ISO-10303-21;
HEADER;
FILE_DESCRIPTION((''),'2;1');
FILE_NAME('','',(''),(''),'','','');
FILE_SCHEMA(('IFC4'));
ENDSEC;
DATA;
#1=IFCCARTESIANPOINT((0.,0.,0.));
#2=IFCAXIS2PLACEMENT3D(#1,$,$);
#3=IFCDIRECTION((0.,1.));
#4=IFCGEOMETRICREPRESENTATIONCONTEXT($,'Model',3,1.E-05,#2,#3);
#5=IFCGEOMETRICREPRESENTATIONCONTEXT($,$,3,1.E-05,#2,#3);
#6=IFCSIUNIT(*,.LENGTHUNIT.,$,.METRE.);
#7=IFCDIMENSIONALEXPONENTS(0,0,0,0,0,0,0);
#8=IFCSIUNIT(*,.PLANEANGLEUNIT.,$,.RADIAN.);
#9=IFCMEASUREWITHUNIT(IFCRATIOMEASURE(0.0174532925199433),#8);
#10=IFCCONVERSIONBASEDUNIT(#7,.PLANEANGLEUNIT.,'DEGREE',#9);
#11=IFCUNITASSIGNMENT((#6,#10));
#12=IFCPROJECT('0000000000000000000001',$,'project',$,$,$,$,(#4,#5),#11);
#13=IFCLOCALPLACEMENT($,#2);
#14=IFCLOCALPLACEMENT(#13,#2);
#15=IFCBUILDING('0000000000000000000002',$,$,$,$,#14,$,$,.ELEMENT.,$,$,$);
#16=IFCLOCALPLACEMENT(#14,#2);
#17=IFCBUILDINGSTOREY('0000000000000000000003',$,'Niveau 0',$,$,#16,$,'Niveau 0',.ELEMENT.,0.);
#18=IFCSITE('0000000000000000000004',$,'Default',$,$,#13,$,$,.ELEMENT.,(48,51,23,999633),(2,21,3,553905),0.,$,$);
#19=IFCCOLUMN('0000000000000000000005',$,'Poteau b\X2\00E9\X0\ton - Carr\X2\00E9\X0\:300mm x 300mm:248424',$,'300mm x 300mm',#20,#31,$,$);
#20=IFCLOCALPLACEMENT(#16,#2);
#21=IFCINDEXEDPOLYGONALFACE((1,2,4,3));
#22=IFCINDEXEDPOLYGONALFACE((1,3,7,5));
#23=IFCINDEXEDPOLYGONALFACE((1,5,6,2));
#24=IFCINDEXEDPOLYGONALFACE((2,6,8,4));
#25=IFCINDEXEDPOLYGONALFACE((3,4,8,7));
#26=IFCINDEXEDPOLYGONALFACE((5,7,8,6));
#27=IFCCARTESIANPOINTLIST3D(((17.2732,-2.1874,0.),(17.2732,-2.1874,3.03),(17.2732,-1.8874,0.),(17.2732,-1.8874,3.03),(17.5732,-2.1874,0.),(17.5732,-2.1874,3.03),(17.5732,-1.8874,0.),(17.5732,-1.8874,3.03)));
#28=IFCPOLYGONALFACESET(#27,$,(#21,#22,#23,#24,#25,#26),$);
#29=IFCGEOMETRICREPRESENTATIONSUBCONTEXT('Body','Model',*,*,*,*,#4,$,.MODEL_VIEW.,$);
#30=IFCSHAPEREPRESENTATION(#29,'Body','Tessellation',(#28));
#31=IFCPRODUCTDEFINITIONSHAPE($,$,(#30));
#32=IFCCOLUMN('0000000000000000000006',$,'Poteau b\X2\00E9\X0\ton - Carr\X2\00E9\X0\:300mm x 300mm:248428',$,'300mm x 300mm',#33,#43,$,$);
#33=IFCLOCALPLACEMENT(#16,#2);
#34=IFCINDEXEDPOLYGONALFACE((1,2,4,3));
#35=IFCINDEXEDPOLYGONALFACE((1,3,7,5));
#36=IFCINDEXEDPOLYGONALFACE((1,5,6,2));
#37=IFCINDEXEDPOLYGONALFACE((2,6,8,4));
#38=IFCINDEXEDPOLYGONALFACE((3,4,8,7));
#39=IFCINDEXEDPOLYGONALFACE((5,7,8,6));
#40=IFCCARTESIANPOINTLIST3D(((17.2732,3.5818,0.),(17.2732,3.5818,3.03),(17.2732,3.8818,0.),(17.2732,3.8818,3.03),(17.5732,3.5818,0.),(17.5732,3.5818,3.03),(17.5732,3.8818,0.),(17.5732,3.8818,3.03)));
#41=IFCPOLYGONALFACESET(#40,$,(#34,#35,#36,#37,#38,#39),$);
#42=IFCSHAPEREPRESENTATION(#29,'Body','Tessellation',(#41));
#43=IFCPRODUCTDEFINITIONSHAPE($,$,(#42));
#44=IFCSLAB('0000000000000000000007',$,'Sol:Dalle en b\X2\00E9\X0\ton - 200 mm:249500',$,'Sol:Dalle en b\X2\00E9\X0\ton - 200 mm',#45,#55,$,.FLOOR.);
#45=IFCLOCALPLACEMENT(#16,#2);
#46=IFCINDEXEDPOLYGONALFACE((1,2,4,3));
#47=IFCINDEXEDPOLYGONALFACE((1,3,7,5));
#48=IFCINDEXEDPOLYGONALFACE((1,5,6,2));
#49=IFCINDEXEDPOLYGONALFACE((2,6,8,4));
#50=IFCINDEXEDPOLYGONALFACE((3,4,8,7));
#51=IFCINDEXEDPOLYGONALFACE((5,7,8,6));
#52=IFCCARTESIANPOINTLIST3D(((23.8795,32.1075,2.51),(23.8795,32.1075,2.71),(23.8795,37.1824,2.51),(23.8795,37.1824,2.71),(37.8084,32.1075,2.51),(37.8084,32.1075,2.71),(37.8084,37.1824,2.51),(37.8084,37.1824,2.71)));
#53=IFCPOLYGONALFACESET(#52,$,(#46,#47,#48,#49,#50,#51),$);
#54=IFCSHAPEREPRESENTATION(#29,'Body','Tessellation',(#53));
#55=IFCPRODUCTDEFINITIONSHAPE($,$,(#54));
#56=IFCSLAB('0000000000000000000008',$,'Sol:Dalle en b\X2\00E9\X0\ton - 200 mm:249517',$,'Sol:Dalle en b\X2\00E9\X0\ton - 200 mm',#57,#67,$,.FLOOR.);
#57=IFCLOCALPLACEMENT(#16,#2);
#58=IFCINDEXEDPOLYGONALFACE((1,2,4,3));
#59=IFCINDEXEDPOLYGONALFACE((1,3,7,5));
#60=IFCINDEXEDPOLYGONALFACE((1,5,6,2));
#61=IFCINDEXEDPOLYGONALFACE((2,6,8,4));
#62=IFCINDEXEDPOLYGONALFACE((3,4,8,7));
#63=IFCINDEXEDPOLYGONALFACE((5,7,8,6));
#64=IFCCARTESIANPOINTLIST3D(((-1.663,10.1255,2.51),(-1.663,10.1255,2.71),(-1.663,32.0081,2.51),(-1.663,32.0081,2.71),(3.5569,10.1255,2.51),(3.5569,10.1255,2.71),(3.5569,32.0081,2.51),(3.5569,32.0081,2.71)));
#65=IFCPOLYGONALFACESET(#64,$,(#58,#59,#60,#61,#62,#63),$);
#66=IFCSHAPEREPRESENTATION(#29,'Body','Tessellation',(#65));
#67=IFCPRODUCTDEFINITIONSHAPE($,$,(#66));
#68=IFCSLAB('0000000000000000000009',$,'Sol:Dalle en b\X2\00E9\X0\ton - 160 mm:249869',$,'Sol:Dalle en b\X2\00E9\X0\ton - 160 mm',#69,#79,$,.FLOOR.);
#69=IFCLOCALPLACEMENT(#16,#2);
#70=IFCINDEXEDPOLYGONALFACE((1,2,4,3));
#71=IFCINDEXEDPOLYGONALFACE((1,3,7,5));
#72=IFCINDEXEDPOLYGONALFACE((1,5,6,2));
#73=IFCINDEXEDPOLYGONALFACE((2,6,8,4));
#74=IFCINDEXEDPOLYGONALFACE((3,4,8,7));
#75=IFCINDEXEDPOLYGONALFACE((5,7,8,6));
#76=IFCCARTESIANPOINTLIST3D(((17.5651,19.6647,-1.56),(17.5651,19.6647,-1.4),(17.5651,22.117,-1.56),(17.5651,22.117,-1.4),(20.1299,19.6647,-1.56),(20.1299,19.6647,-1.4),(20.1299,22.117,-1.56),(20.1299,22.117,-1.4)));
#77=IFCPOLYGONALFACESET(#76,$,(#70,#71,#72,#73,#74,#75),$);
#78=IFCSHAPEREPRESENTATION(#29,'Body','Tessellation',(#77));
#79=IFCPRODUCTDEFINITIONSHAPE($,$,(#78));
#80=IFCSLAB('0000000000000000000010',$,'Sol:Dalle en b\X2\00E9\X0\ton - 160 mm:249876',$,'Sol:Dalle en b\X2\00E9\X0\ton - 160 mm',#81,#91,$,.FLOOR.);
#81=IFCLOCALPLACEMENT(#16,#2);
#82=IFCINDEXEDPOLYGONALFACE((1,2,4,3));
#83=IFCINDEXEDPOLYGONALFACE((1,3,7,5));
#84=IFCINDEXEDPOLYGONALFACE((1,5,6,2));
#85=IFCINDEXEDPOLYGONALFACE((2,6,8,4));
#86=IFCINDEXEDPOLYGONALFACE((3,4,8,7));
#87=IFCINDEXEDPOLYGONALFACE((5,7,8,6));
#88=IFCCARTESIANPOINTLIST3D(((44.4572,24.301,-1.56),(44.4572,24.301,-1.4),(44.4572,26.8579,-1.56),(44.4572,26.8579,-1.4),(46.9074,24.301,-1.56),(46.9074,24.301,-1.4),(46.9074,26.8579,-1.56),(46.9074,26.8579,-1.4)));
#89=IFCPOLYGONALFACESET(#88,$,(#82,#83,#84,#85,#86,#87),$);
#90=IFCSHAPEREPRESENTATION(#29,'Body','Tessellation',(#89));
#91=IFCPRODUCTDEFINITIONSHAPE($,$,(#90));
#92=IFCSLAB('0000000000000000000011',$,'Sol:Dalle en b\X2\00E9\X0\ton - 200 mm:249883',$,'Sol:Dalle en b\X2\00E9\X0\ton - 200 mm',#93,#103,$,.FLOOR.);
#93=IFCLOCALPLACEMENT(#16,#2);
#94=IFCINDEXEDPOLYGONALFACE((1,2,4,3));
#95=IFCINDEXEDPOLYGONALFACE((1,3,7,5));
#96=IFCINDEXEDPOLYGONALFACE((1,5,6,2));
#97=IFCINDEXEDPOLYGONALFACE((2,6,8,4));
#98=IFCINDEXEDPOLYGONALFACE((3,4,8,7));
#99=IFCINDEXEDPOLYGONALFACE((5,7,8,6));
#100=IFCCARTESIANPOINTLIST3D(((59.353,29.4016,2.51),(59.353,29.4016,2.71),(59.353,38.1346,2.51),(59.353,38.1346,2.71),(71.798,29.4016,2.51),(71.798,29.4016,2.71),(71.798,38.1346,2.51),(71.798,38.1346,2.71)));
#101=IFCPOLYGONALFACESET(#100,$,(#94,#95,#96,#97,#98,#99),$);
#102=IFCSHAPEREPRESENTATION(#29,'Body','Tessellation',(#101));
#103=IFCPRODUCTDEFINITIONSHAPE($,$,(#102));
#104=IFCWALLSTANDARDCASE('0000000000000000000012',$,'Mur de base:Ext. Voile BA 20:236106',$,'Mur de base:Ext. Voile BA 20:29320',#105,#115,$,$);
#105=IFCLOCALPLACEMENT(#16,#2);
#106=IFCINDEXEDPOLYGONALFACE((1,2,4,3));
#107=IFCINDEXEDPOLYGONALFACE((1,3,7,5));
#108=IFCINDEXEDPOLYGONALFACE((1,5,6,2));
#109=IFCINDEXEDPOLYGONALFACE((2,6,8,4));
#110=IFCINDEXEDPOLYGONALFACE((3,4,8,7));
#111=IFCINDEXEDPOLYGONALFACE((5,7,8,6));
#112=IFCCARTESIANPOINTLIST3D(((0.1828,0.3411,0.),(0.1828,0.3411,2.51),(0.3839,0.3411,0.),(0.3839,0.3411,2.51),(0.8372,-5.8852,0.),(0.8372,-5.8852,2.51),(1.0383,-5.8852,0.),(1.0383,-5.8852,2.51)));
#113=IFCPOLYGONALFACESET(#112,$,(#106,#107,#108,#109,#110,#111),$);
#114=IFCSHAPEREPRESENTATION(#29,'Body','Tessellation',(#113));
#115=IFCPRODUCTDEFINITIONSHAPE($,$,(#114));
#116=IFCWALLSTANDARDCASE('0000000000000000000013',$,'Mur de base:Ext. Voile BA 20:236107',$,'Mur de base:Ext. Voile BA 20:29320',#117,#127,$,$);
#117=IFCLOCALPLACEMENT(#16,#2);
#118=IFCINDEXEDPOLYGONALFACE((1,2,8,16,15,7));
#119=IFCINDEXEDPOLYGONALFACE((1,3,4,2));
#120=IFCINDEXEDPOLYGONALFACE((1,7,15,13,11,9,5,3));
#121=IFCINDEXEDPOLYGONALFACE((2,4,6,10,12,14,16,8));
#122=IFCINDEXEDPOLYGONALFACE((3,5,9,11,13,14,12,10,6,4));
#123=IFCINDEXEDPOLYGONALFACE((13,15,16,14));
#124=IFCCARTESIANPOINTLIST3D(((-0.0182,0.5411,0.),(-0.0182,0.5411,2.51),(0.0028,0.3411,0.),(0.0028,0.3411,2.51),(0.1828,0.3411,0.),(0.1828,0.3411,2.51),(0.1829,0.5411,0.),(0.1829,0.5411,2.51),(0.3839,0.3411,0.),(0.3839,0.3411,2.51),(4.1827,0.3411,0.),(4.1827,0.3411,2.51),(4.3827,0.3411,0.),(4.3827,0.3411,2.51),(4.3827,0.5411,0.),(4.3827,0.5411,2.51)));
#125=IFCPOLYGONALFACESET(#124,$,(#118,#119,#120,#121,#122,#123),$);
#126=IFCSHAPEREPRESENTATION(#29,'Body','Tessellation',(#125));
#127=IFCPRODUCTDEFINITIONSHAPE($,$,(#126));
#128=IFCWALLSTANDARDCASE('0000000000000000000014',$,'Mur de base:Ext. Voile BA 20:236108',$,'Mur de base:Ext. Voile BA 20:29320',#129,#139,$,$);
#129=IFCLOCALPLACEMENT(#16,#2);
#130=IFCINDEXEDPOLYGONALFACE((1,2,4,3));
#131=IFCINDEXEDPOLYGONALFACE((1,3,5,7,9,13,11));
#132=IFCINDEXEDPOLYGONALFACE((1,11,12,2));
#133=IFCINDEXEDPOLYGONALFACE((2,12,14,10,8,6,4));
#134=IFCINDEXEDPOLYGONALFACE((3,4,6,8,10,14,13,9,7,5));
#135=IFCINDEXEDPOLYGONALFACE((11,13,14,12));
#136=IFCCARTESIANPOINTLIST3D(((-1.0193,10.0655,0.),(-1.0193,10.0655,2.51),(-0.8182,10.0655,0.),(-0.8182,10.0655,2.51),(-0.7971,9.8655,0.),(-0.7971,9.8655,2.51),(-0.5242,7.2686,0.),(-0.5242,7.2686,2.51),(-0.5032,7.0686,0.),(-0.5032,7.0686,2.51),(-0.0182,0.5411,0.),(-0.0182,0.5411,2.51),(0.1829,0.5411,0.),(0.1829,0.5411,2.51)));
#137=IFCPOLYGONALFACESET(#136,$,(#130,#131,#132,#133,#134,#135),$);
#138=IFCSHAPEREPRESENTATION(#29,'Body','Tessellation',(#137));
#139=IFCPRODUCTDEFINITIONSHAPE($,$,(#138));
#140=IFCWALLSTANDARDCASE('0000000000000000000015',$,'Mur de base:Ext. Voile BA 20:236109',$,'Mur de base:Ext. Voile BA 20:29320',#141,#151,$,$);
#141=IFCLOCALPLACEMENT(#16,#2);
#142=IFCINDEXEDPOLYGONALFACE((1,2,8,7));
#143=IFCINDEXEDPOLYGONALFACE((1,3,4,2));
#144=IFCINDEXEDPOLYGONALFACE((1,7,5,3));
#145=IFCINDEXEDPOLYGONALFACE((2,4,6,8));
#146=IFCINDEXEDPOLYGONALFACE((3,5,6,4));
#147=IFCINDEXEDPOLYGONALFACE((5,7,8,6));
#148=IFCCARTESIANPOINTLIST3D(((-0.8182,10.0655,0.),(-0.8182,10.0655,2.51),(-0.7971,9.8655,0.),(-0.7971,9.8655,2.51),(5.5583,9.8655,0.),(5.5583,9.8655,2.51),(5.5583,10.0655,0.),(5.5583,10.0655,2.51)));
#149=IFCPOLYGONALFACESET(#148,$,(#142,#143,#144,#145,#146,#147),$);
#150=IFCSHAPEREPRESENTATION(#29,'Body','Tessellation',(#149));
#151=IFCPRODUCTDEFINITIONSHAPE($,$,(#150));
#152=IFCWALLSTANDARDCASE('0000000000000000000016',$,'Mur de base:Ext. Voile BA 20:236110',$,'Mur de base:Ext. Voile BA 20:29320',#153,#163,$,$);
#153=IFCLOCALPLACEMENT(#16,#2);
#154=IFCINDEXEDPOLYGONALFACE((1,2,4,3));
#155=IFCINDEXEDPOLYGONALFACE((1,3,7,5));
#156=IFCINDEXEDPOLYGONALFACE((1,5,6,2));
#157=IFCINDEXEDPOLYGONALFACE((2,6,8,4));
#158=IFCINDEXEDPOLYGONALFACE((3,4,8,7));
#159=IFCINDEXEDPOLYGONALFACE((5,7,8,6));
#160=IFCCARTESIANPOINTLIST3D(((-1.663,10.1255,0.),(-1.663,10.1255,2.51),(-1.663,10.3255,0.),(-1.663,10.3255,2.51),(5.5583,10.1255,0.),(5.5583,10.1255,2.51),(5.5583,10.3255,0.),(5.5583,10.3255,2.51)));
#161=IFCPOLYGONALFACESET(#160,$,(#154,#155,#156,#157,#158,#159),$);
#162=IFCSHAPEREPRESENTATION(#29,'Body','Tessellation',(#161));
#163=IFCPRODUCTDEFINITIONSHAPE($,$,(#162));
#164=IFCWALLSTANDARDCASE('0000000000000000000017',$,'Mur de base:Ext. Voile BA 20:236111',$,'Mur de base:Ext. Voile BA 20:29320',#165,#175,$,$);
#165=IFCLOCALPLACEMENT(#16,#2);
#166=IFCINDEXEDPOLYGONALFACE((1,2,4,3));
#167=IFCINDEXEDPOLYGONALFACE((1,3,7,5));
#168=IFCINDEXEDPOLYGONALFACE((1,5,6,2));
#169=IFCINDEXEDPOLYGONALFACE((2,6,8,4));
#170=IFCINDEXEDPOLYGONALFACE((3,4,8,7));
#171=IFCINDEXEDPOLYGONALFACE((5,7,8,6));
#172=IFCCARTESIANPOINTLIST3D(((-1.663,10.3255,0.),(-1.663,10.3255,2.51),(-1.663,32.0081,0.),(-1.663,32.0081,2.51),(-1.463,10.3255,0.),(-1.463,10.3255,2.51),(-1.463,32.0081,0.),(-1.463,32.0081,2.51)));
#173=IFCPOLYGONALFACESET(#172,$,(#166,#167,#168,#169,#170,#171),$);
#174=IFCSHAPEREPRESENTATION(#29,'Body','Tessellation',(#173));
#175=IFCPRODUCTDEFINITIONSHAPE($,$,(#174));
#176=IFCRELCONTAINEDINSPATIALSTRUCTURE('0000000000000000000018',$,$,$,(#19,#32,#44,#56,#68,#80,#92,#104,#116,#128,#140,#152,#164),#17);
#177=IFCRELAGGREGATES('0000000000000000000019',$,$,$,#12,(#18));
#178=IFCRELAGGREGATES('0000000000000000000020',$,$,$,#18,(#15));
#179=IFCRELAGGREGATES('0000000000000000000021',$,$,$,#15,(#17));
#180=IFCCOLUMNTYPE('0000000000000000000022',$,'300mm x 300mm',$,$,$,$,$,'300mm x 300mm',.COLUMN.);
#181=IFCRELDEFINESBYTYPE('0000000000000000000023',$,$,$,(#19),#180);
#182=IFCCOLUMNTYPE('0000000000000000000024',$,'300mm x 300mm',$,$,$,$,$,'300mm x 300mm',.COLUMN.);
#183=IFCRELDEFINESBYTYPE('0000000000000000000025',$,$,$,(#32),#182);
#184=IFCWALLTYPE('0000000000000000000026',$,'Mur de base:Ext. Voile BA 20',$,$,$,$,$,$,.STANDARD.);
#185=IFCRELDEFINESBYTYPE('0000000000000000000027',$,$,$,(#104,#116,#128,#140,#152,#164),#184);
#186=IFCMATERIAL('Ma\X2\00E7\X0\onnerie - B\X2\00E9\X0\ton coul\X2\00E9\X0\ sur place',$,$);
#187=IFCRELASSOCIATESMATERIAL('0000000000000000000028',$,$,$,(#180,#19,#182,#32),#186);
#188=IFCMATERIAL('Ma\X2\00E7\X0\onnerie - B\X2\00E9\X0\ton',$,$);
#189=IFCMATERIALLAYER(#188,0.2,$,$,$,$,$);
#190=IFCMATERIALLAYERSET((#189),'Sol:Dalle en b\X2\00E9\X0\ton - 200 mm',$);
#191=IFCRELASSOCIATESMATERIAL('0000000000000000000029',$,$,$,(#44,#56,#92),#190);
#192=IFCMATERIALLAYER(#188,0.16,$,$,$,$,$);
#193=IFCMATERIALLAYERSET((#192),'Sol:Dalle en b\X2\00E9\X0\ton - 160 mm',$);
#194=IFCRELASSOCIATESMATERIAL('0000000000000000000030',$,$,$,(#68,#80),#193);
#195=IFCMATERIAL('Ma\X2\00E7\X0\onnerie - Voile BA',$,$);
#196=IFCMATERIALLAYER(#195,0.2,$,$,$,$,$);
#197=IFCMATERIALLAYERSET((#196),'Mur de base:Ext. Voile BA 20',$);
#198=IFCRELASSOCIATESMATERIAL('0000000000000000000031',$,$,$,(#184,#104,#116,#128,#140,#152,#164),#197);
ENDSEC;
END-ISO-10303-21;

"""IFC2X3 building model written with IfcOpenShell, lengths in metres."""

from ifc_helpers import new_model, entity, si_unit, converted_unit, direction, frame, frame_2d, origin, origin_2d_with_axis, place, context, subcontext, project, spatial, polyline, rectangle, outline, extrude, source, transform, mapped, material, layer, layer_set, layer_usage, type_object, type_shapes, element, save


model = new_model("IFC2X3")

# Units and contexts
model_context = context("Model", 3, precision=1e-05, world=origin(), true_north=direction((0.0, 1.0)))
context_of_model = context(None, 3, precision=1e-05, world=origin(), true_north=direction((0.0, 1.0)))
body_context = subcontext(model_context, "Body", "Model", "MODEL_VIEW")
ifc_project = project(units=[si_unit("LENGTHUNIT", "METRE"), converted_unit("PLANEANGLEUNIT", "DEGREE", entity("IfcRatioMeasure", 0.0174532925199433), si_unit("PLANEANGLEUNIT", "RADIAN"), dimensions=[0, 0, 0, 0, 0, 0, 0])], contexts=[model_context, context_of_model])

# Site, building, storey
site_placement = place(None, origin())
site = spatial("IfcSite", under=ifc_project, at=site_placement, Name="Default", CompositionType="ELEMENT", RefLatitude=(48, 51, 23, 999633), RefLongitude=(2, 21, 3, 553905), RefElevation=0.0)
building_placement = place(site_placement, origin())
building = spatial("IfcBuilding", under=site, at=building_placement, CompositionType="ELEMENT")
storey_placement = place(building_placement, origin())
storey = spatial("IfcBuildingStorey", under=building, at=storey_placement, Name="Niveau 0", LongName="Niveau 0", CompositionType="ELEMENT", Elevation=0.0)

# Columns
ifc_material_1 = material(Name="Maçonnerie - Béton coulé sur place")
column_type_1 = type_object("IfcColumnType", Name="300mm x 300mm", ElementType="300mm x 300mm", PredefinedType="COLUMN", material=ifc_material_1)
shared_shape_1 = source(origin(), body_context, "Body", "SweptSolid", [
    extrude(rectangle(XDim=0.3, YDim=0.3, at=frame_2d((0.0, 0.0), x_axis=(1.0, 0.0))), frame((17.4232, -2.0374, 0.0), z_axis=(0.0, 0.0, 1.0), x_axis=(-1.0, 0.0, 0.0)), (0.0, 0.0, 1.0), 3.03),
])
type_shapes(column_type_1, [shared_shape_1])
column_1_placement = place(storey_placement, origin())
element("IfcColumn", 1, at=column_1_placement, inside=storey, type_object=column_type_1, material=ifc_material_1, Name="Poteau béton - Carré:300mm x 300mm:248424", ObjectType="300mm x 300mm", context=body_context, shape_type="MappedRepresentation", body=[
    mapped(shared_shape_1, transform((0.0, 0.0, 0.0), scale=1.0)),
])
column_type_2 = type_object("IfcColumnType", Name="300mm x 300mm", ElementType="300mm x 300mm", PredefinedType="COLUMN", material=ifc_material_1)
shared_shape_2 = source(origin(), body_context, "Body", "SweptSolid", [
    extrude(rectangle(XDim=0.3, YDim=0.3, at=frame_2d((0.0, 0.0), x_axis=(1.0, 0.0))), frame((17.4232, 3.7318, 0.0), z_axis=(0.0, 0.0, 1.0), x_axis=(-1.0, 0.0, 0.0)), (0.0, 0.0, 1.0), 3.03),
])
type_shapes(column_type_2, [shared_shape_2])
column_2_placement = place(storey_placement, origin())
element("IfcColumn", 2, at=column_2_placement, inside=storey, type_object=column_type_2, material=ifc_material_1, Name="Poteau béton - Carré:300mm x 300mm:248428", ObjectType="300mm x 300mm", context=body_context, shape_type="MappedRepresentation", body=[
    mapped(shared_shape_2, transform((0.0, 0.0, 0.0), scale=1.0)),
])

# Slabs
ifc_material_2 = material(Name="Maçonnerie - Béton")
ifc_layer_1 = layer(ifc_material_2, 0.2)
ifc_layer_set_1 = layer_set([ifc_layer_1], Name="Sol:Dalle en béton - 200 mm")
ifc_layer_usage_1 = layer_usage(ifc_layer_set_1, "AXIS3", "POSITIVE", 0.0)
slab_1_placement = place(storey_placement, origin())
element("IfcSlab", 3, at=slab_1_placement, inside=storey, material=ifc_layer_usage_1, Name="Sol:Dalle en béton - 200 mm:249500", ObjectType="Sol:Dalle en béton - 200 mm", PredefinedType="FLOOR", context=body_context, shape_type="SweptSolid", body=[
    extrude(rectangle(XDim=5.0749, YDim=13.9289, at=frame_2d((0.0, 0.0), x_axis=(1.0, 0.0))), frame((30.8439, 34.645, 2.71), z_axis=(0.0, 0.0, -1.0), x_axis=(0.0, 1.0, 0.0)), (0.0, 0.0, 1.0), 0.2),
])
ifc_layer_usage_2 = layer_usage(ifc_layer_set_1, "AXIS3", "POSITIVE", 0.0)
slab_2_placement = place(storey_placement, origin())
element("IfcSlab", 4, at=slab_2_placement, inside=storey, material=ifc_layer_usage_2, Name="Sol:Dalle en béton - 200 mm:249517", ObjectType="Sol:Dalle en béton - 200 mm", PredefinedType="FLOOR", context=body_context, shape_type="SweptSolid", body=[
    extrude(rectangle(XDim=21.8826, YDim=5.2199, at=frame_2d((0.0, 0.0), x_axis=(1.0, 0.0))), frame((0.947, 21.0668, 2.71), z_axis=(0.0, 0.0, -1.0), x_axis=(0.0, 1.0, 0.0)), (0.0, 0.0, 1.0), 0.2),
])
ifc_layer_2 = layer(ifc_material_2, 0.16)
ifc_layer_set_2 = layer_set([ifc_layer_2], Name="Sol:Dalle en béton - 160 mm")
ifc_layer_usage_3 = layer_usage(ifc_layer_set_2, "AXIS3", "POSITIVE", 0.0)
slab_3_placement = place(storey_placement, origin())
element("IfcSlab", 5, at=slab_3_placement, inside=storey, material=ifc_layer_usage_3, Name="Sol:Dalle en béton - 160 mm:249869", ObjectType="Sol:Dalle en béton - 160 mm", PredefinedType="FLOOR", context=body_context, shape_type="SweptSolid", body=[
    extrude(rectangle(XDim=2.4523, YDim=2.5648, at=origin_2d_with_axis()), frame((18.8475, 20.8908, -1.4), z_axis=(0.0, 0.0, -1.0), x_axis=(0.0, 1.0, 0.0)), (0.0, 0.0, 1.0), 0.16),
])
ifc_layer_usage_4 = layer_usage(ifc_layer_set_2, "AXIS3", "POSITIVE", 0.0)
slab_4_placement = place(storey_placement, origin())
element("IfcSlab", 6, at=slab_4_placement, inside=storey, material=ifc_layer_usage_4, Name="Sol:Dalle en béton - 160 mm:249876", ObjectType="Sol:Dalle en béton - 160 mm", PredefinedType="FLOOR", context=body_context, shape_type="SweptSolid", body=[
    extrude(rectangle(XDim=2.5569, YDim=2.4501, at=frame_2d((0.0, 0.0), x_axis=(1.0, 0.0))), frame((45.6823, 25.5794, -1.4), z_axis=(0.0, 0.0, -1.0), x_axis=(0.0, 1.0, 0.0)), (0.0, 0.0, 1.0), 0.16),
])
ifc_layer_usage_5 = layer_usage(ifc_layer_set_1, "AXIS3", "POSITIVE", 0.0)
slab_5_placement = place(storey_placement, origin())
element("IfcSlab", 7, at=slab_5_placement, inside=storey, material=ifc_layer_usage_5, Name="Sol:Dalle en béton - 200 mm:249883", ObjectType="Sol:Dalle en béton - 200 mm", PredefinedType="FLOOR", context=body_context, shape_type="SweptSolid", body=[
    extrude(rectangle(XDim=8.733, YDim=12.445, at=origin_2d_with_axis()), frame((65.5755, 33.7681, 2.71), z_axis=(0.0, 0.0, -1.0), x_axis=(0.0, 1.0, 0.0)), (0.0, 0.0, 1.0), 0.2),
])

# Walls
ifc_material_3 = material(Name="Maçonnerie - Voile BA")
ifc_layer_3 = layer(ifc_material_3, 0.2)
ifc_layer_set_3 = layer_set([ifc_layer_3], Name="Mur de base:Ext. Voile BA 20")
ifc_layer_usage_6 = layer_usage(ifc_layer_set_3, "AXIS2", "NEGATIVE", 0.1)
wall_type = type_object("IfcWallType", Name="Mur de base:Ext. Voile BA 20", PredefinedType="STANDARD", material=ifc_layer_set_3)
wall_1_placement = place(storey_placement, frame((0.9389, -5.8956, 0.0), z_axis=(0.0, 0.0, 1.0), x_axis=(-0.104528, 0.994522, 0.0)))
element("IfcWallStandardCase", 8, at=wall_1_placement, inside=storey, type_object=wall_type, material=ifc_layer_usage_6, Name="Mur de base:Ext. Voile BA 20:236106", ObjectType="Mur de base:Ext. Voile BA 20:29320", context=body_context, shape_type="SweptSolid", body=[
    extrude(outline(polyline([(6.2606, -0.1), (6.2816, 0.1), (0.021, 0.1), (0.0, -0.1), (6.2606, -0.1)])), origin(), (0.0, 0.0, 1.0), 2.51),
])
ifc_layer_usage_7 = layer_usage(ifc_layer_set_3, "AXIS2", "NEGATIVE", 0.1)
wall_2_placement = place(storey_placement, frame((4.3827, 0.4411, 0.0), z_axis=(0.0, 0.0, 1.0), x_axis=(-1.0, 0.0, 0.0)))
element("IfcWallStandardCase", 9, at=wall_2_placement, inside=storey, type_object=wall_type, material=ifc_layer_usage_7, Name="Mur de base:Ext. Voile BA 20:236107", ObjectType="Mur de base:Ext. Voile BA 20:29320", context=body_context, shape_type="SweptSolid", body=[
    extrude(outline(polyline([(4.4009, -0.1), (4.3799, 0.1), (4.1999, 0.1), (3.9988, 0.1), (0.2, 0.1), (0.0, 0.1), (0.0, -0.1), (4.1998, -0.1), (4.4009, -0.1)])), origin(), (0.0, 0.0, 1.0), 2.51),
])
ifc_layer_usage_8 = layer_usage(ifc_layer_set_3, "AXIS2", "NEGATIVE", 0.1)
wall_3_placement = place(storey_placement, frame((0.0834, 0.5307, 0.0), z_axis=(0.0, 0.0, 1.0), x_axis=(-0.104528, 0.994522, 0.0)))
element("IfcWallStandardCase", 10, at=wall_3_placement, inside=storey, type_object=wall_type, material=ifc_layer_usage_8, Name="Mur de base:Ext. Voile BA 20:236108", ObjectType="Mur de base:Ext. Voile BA 20:29320", context=body_context, shape_type="SweptSolid", body=[
    extrude(outline(polyline([(9.5768, -0.1), (9.5978, 0.1), (0.021, 0.1), (0.0, -0.1), (6.5634, -0.1), (6.7645, -0.1), (9.3757, -0.1), (9.5768, -0.1)])), origin(), (0.0, 0.0, 1.0), 2.51),
])
ifc_layer_usage_9 = layer_usage(ifc_layer_set_3, "AXIS2", "NEGATIVE", 0.1)
wall_4_placement = place(storey_placement, frame((-0.8182, 9.9655, 0.0)))
element("IfcWallStandardCase", 11, at=wall_4_placement, inside=storey, type_object=wall_type, material=ifc_layer_usage_9, Name="Mur de base:Ext. Voile BA 20:236109", ObjectType="Mur de base:Ext. Voile BA 20:29320", context=body_context, shape_type="SweptSolid", body=[
    extrude(outline(polyline([(6.3765, -0.1), (6.3765, 0.1), (0.0, 0.1), (0.021, -0.1), (6.3765, -0.1)])), origin(), (0.0, 0.0, 1.0), 2.51),
])
ifc_layer_usage_10 = layer_usage(ifc_layer_set_3, "AXIS2", "NEGATIVE", 0.1)
wall_5_placement = place(storey_placement, frame((5.5583, 10.2255, 0.0), z_axis=(0.0, 0.0, 1.0), x_axis=(-1.0, 0.0, 0.0)))
element("IfcWallStandardCase", 12, at=wall_5_placement, inside=storey, type_object=wall_type, material=ifc_layer_usage_10, Name="Mur de base:Ext. Voile BA 20:236110", ObjectType="Mur de base:Ext. Voile BA 20:29320", context=body_context, shape_type="SweptSolid", body=[
    extrude(rectangle(XDim=7.2213, YDim=0.2, at=frame_2d((3.6107, 0.0), x_axis=(-1.0, 0.0))), origin(), (0.0, 0.0, 1.0), 2.51),
])
ifc_layer_usage_11 = layer_usage(ifc_layer_set_3, "AXIS2", "NEGATIVE", 0.1)
wall_6_placement = place(storey_placement, frame((-1.563, 10.3255, 0.0), z_axis=(0.0, 0.0, 1.0), x_axis=(0.0, 1.0, 0.0)))
element("IfcWallStandardCase", 13, at=wall_6_placement, inside=storey, type_object=wall_type, material=ifc_layer_usage_11, Name="Mur de base:Ext. Voile BA 20:236111", ObjectType="Mur de base:Ext. Voile BA 20:29320", context=body_context, shape_type="SweptSolid", body=[
    extrude(rectangle(XDim=21.6826, YDim=0.2, at=frame_2d((10.8413, 0.0), x_axis=(-1.0, 0.0))), origin(), (0.0, 0.0, 1.0), 2.51),
])

save(model, "model.ifc")
